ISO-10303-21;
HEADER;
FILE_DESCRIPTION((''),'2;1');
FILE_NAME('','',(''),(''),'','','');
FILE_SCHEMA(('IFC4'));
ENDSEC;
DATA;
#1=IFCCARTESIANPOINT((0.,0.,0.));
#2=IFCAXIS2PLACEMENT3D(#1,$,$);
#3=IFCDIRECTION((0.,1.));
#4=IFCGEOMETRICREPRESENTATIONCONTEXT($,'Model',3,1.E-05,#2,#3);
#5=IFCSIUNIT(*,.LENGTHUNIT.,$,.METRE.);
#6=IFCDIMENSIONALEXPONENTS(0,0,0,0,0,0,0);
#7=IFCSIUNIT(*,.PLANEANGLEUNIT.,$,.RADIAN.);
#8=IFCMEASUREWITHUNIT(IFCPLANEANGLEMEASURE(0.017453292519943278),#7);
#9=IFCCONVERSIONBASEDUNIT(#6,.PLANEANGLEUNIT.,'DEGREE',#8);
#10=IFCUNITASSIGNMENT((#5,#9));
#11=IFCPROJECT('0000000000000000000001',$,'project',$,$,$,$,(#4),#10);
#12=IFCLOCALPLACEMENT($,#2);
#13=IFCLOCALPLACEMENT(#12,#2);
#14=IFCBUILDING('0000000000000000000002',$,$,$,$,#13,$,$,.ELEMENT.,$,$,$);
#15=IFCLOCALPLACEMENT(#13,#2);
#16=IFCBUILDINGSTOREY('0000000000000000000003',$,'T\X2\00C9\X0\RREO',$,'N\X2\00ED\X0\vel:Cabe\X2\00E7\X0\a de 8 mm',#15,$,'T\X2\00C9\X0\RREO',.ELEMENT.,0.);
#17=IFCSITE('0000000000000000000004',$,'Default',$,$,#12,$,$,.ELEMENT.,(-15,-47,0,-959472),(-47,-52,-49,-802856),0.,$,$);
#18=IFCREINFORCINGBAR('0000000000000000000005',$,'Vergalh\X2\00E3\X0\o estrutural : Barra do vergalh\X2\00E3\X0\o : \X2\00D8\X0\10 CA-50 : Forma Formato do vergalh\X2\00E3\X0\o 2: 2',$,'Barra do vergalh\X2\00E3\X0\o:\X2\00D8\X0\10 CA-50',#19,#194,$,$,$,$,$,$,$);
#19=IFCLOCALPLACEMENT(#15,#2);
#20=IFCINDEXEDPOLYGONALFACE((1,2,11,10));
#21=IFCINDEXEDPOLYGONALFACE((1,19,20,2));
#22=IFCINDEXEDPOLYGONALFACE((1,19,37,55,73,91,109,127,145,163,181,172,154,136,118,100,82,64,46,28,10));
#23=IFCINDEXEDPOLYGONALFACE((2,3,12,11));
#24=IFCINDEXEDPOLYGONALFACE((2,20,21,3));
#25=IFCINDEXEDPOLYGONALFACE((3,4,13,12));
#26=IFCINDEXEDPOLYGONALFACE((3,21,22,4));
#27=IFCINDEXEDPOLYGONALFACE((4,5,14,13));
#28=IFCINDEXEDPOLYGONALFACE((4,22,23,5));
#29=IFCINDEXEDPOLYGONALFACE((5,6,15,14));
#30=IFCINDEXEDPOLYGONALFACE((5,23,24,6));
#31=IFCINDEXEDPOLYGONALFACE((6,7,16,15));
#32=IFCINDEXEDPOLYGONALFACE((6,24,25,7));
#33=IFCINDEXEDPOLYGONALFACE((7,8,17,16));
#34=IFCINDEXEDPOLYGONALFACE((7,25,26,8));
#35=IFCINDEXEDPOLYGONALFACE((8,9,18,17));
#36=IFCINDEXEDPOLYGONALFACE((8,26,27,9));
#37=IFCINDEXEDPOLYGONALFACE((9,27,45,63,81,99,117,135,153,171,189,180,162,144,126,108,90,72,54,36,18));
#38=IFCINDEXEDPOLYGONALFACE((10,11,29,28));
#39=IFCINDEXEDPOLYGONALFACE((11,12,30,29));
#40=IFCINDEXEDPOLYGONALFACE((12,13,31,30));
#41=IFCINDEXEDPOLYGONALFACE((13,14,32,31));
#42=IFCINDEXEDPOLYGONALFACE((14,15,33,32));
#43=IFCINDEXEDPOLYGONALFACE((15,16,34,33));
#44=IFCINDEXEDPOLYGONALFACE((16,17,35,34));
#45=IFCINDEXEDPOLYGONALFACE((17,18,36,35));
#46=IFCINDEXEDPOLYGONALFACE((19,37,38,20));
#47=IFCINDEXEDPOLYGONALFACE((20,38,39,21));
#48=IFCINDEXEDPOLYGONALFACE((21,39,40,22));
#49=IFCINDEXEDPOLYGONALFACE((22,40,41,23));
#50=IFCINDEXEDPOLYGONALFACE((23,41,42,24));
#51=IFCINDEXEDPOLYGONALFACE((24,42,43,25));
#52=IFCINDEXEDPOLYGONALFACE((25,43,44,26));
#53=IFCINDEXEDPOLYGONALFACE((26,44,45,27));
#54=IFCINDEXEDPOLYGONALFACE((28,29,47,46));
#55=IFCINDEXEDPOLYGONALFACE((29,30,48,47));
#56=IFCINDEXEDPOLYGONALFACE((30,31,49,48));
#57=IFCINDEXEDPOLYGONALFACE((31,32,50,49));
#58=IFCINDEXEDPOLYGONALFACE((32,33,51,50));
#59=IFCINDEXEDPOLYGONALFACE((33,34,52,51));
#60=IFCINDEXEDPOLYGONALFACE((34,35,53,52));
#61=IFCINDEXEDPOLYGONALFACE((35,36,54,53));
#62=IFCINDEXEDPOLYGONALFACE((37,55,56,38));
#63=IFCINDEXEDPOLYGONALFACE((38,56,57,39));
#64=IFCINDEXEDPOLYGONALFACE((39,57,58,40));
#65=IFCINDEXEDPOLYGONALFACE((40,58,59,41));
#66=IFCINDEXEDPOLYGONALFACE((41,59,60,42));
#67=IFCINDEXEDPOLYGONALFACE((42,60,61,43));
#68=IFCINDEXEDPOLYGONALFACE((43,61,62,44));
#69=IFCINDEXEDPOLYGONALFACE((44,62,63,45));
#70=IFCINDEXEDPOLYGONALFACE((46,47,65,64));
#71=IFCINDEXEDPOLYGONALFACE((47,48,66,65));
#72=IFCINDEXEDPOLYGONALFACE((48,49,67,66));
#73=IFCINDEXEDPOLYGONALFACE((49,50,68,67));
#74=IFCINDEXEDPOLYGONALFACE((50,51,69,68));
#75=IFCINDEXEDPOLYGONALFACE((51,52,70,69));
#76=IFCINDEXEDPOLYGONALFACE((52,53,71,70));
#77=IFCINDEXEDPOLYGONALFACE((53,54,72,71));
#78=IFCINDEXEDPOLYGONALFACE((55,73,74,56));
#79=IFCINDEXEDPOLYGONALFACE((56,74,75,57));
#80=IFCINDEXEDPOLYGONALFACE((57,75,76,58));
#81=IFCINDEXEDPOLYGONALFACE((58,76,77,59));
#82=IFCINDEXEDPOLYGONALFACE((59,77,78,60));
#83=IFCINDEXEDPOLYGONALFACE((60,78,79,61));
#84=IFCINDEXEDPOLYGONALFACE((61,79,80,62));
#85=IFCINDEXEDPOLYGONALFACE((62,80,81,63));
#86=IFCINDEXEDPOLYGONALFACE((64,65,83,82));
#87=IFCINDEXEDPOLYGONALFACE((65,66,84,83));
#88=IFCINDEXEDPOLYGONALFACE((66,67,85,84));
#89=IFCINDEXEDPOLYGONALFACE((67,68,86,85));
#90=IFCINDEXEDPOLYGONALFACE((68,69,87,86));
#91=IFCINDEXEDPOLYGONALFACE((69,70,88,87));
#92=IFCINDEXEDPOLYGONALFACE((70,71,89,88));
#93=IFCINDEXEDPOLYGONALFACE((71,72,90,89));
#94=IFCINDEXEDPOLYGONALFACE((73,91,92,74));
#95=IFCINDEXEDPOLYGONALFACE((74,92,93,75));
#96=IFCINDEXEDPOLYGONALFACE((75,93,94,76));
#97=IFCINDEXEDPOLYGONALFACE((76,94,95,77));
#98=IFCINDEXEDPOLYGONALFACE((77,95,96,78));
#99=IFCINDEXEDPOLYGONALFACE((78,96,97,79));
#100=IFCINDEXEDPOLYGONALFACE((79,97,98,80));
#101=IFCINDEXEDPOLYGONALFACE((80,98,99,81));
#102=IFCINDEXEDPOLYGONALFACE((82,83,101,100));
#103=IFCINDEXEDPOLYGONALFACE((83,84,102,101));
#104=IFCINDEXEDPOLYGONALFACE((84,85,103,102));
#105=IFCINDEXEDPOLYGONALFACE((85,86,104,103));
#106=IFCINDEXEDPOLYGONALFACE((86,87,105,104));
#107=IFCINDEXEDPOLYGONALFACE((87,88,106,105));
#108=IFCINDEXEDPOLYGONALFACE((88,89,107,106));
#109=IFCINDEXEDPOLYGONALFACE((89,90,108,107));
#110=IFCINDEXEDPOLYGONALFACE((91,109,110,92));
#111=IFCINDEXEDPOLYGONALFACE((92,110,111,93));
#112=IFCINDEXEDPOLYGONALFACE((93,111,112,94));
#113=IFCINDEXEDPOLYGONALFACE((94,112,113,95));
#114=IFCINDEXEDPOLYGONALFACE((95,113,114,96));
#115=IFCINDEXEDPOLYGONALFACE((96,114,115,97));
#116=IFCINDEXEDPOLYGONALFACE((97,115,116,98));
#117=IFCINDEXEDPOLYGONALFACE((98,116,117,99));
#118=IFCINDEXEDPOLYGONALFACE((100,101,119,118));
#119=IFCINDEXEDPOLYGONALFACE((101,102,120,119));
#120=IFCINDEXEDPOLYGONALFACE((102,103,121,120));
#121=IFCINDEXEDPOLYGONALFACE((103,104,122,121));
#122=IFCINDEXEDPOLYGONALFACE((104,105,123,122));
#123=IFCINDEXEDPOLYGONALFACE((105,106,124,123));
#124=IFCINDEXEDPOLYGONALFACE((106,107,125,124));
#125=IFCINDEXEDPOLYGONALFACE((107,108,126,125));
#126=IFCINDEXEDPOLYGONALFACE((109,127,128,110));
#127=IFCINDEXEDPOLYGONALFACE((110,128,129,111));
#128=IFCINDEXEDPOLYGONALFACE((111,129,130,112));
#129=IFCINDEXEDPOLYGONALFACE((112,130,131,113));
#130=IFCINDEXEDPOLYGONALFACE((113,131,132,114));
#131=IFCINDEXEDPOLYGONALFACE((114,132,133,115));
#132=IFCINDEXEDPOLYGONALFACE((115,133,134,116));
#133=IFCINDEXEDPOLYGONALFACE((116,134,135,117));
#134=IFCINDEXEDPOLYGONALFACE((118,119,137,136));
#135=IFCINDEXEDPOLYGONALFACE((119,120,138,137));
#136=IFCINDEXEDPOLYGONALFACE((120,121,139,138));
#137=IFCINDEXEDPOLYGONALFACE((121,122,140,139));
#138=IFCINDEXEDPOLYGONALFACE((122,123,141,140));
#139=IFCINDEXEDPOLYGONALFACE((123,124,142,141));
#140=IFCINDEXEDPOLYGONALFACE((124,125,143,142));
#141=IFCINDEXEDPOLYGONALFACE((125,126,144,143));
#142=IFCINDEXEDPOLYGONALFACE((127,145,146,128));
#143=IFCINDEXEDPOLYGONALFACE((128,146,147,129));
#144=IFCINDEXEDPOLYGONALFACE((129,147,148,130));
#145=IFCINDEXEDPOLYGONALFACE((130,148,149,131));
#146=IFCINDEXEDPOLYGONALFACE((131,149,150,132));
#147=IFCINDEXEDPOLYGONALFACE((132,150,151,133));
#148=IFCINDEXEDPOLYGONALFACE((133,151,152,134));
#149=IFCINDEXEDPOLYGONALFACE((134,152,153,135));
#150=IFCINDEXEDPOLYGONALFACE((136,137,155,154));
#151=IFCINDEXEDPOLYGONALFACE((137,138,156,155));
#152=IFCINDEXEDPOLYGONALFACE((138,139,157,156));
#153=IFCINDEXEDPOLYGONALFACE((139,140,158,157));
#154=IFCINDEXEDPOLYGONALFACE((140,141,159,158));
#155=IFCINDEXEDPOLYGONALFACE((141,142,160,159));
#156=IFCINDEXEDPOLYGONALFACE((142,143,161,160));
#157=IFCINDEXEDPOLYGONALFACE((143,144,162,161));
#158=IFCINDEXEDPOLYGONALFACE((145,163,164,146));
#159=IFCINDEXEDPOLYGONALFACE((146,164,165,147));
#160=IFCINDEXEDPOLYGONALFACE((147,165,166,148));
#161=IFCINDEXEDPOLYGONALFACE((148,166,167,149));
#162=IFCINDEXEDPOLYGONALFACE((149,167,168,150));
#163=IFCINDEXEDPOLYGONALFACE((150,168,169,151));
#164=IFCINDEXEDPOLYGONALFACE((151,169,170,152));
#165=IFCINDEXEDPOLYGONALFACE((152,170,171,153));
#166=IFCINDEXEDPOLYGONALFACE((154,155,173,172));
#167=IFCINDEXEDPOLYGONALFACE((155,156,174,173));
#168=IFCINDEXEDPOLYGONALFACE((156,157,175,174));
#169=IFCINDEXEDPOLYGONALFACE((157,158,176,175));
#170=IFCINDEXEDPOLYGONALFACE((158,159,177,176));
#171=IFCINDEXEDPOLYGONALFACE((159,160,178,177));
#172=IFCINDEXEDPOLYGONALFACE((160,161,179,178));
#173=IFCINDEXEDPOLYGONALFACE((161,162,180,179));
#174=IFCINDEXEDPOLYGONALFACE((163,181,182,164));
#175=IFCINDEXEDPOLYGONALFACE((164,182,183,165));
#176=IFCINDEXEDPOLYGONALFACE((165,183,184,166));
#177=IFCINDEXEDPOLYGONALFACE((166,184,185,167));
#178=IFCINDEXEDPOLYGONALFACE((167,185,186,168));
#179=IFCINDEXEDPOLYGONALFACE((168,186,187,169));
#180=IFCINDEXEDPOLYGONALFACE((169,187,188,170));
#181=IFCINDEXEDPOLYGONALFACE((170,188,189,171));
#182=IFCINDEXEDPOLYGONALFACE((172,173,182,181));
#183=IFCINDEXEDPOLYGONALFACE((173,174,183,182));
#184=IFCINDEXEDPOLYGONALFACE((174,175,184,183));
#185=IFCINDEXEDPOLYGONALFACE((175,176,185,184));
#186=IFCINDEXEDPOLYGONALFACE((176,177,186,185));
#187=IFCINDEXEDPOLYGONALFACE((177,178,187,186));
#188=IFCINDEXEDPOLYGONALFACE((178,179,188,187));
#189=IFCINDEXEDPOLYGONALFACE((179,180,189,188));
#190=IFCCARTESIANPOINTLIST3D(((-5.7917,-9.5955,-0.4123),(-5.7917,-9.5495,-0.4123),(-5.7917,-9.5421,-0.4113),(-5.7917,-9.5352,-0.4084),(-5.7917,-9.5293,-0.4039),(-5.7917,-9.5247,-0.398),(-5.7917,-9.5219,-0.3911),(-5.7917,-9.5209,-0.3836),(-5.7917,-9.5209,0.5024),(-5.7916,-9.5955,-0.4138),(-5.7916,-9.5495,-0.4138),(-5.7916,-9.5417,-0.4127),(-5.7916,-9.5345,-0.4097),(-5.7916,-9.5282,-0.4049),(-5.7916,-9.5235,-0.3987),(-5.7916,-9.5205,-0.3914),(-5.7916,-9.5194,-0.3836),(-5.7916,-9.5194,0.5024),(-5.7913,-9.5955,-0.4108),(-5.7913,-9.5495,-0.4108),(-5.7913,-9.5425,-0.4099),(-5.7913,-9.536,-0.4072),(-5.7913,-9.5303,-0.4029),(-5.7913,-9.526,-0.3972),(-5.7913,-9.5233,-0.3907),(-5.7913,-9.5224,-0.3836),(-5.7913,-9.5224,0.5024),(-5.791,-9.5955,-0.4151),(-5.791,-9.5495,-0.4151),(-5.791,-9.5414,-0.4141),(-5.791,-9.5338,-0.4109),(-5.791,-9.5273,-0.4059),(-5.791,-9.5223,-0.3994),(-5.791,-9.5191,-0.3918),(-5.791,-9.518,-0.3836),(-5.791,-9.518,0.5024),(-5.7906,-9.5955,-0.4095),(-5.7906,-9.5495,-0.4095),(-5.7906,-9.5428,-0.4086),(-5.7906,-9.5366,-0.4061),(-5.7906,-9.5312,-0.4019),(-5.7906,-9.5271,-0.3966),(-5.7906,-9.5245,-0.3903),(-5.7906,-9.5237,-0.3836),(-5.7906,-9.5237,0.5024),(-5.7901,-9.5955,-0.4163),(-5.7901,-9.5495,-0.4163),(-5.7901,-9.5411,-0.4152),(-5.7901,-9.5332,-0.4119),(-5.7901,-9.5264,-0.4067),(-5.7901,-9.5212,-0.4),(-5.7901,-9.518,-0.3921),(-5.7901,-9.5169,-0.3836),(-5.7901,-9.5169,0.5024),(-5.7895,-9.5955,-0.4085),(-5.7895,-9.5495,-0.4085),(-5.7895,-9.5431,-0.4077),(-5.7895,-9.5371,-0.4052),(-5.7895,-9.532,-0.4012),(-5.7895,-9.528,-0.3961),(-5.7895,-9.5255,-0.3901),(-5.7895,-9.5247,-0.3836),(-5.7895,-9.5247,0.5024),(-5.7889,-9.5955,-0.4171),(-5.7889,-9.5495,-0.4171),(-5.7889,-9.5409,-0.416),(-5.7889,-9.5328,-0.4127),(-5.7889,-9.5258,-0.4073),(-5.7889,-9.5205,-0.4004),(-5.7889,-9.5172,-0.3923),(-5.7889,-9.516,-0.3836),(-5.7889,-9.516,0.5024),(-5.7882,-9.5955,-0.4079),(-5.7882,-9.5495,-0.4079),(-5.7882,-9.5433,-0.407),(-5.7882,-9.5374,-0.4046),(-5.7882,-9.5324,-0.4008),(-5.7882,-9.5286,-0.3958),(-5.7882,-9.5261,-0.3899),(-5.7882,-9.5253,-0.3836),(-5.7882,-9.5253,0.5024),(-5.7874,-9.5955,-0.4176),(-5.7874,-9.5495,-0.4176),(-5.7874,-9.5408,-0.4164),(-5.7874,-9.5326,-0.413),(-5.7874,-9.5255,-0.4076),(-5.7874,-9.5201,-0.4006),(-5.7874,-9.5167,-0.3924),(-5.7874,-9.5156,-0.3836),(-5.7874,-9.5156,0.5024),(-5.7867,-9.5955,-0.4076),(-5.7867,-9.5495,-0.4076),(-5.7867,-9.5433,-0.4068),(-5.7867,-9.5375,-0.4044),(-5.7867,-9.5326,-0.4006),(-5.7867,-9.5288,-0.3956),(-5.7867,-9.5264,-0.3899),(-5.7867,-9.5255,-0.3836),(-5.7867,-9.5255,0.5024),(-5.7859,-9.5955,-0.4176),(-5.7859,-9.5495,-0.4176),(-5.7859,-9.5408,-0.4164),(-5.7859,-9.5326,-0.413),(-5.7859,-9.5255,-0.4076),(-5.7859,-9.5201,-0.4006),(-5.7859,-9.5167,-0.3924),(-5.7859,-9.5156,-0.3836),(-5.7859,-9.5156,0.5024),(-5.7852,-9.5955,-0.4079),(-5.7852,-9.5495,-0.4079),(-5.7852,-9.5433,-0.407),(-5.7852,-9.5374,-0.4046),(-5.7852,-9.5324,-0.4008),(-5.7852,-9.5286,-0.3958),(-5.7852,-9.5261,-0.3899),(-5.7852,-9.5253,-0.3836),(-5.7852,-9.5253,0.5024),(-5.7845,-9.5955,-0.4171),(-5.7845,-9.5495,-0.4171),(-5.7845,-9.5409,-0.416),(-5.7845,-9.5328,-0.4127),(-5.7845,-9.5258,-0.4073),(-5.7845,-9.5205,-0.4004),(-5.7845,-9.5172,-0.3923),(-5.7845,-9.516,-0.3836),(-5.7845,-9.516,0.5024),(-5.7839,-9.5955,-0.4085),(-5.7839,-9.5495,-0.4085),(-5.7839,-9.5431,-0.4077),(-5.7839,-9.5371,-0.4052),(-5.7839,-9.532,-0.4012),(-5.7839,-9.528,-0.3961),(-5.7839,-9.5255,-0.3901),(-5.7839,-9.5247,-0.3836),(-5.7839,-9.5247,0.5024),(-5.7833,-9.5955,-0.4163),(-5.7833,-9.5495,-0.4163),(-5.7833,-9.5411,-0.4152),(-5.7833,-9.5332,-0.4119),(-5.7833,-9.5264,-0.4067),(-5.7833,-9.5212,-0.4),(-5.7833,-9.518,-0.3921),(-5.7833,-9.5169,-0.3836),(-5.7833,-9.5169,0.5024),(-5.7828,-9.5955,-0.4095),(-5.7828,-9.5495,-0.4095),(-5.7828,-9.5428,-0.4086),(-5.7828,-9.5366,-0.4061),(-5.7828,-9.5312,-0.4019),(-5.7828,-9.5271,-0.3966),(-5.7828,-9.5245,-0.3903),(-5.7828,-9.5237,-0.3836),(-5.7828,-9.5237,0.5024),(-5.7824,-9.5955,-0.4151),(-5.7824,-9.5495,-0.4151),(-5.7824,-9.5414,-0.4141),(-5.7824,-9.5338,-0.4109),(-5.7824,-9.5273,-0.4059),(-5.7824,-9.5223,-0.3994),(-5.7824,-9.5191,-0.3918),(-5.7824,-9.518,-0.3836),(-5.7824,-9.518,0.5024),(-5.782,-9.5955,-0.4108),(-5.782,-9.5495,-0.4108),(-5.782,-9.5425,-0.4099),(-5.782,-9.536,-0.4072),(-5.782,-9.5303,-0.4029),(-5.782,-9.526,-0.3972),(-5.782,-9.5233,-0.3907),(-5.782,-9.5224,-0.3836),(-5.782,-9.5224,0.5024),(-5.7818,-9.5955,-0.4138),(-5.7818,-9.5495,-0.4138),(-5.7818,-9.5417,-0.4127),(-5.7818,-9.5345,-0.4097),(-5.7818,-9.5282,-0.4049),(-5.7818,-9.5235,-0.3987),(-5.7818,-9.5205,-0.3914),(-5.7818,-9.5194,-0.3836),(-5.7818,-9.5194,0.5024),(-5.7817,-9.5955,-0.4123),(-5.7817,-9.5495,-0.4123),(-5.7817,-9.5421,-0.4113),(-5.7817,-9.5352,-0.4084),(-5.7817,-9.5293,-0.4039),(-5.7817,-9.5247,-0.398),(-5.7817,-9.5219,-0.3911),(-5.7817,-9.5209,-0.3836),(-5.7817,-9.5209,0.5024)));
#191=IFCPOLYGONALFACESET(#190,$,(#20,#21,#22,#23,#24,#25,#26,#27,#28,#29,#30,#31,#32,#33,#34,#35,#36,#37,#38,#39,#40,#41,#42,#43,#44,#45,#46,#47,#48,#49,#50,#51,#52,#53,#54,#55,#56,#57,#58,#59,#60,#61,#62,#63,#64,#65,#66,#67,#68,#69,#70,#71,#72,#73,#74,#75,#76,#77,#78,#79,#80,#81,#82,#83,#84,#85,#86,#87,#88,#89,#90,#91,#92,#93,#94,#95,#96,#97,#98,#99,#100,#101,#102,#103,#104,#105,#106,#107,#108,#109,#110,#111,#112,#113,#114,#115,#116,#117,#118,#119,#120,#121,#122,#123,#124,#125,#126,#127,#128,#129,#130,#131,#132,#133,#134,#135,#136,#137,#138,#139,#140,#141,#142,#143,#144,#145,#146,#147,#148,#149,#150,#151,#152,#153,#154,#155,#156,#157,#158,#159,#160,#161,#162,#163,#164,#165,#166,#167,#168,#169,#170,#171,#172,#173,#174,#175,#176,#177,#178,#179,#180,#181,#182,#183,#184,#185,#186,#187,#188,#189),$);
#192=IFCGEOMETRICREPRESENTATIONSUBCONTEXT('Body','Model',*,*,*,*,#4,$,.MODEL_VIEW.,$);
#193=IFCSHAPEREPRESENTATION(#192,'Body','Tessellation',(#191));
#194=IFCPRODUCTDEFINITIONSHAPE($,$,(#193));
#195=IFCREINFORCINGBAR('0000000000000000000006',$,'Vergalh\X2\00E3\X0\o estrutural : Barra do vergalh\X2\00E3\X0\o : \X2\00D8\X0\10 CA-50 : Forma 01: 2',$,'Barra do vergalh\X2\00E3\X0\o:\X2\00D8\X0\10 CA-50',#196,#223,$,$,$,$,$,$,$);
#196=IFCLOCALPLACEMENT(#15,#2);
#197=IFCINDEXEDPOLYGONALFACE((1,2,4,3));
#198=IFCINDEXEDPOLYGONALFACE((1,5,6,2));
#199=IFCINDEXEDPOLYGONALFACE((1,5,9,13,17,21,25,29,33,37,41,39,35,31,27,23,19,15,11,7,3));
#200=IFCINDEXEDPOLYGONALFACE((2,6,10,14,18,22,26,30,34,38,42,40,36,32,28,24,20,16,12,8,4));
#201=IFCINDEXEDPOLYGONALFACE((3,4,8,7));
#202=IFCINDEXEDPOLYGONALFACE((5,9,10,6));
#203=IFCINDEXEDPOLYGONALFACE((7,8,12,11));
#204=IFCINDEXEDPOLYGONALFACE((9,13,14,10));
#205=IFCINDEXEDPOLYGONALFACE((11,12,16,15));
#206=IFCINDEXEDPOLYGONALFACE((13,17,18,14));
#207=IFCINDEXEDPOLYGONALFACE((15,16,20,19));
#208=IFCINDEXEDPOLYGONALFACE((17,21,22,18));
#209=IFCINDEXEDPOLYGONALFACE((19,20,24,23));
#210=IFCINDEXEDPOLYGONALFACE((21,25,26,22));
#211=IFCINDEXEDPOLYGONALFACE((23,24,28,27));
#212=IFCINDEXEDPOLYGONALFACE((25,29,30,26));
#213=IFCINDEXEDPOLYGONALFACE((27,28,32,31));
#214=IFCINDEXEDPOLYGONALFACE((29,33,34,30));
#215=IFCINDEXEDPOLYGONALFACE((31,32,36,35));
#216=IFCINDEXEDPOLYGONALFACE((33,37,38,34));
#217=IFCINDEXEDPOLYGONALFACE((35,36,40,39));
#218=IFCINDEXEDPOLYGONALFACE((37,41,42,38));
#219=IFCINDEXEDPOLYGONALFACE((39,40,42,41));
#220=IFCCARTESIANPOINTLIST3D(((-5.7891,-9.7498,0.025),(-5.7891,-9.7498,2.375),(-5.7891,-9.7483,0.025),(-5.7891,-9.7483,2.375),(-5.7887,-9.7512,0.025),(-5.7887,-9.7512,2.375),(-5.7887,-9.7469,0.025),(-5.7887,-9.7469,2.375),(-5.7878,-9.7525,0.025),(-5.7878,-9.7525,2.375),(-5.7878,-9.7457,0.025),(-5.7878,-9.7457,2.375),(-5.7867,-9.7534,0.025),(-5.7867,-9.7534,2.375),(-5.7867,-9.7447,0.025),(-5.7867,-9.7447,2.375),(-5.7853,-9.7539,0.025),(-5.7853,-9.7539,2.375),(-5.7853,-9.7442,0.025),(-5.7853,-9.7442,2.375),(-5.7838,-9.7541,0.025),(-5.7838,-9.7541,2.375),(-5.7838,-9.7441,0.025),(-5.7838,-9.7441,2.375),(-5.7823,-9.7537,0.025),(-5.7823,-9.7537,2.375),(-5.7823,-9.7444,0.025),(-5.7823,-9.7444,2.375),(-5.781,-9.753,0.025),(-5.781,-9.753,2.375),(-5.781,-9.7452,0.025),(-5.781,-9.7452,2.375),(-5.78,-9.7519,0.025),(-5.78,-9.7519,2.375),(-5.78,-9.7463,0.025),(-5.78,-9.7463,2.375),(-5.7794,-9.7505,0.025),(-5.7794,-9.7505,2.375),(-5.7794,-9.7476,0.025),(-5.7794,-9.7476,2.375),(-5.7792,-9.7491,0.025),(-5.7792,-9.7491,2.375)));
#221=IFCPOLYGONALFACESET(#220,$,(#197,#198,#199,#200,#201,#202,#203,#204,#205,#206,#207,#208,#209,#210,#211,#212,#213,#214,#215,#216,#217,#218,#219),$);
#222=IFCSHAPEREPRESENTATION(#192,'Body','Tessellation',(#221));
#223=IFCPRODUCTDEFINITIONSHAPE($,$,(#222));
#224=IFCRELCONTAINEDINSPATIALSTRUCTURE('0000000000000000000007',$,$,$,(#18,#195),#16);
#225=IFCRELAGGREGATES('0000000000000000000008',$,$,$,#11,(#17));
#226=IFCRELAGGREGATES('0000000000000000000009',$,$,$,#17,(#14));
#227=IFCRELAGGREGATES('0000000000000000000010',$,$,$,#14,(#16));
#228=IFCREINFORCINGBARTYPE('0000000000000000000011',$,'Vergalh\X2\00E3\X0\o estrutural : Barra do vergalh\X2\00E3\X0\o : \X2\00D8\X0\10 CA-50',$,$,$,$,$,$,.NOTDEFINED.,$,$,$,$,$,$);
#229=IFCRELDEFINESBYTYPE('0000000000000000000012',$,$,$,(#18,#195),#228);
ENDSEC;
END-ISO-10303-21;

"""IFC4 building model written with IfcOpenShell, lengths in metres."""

from ifc_helpers import new_model, entity, si_unit, converted_unit, direction, origin, place, context, subcontext, project, spatial, type_object, element, save


model = new_model("IFC4")

# Units and contexts
model_context = context("Model", 3, precision=1e-05, world=origin(), true_north=direction((0.0, 1.0)))
body_context = subcontext(model_context, "Body", "Model", "MODEL_VIEW")
ifc_project = project(units=[si_unit("LENGTHUNIT", "METRE"), converted_unit("PLANEANGLEUNIT", "DEGREE", entity("IfcPlaneAngleMeasure", 0.017453292519943278), si_unit("PLANEANGLEUNIT", "RADIAN"), dimensions=[0, 0, 0, 0, 0, 0, 0])], contexts=[model_context])

# Site, building, storey
site_placement = place(None, origin())
site = spatial("IfcSite", under=ifc_project, at=site_placement, Name="Default", CompositionType="ELEMENT", RefLatitude=(-15, -47, 0, -959472), RefLongitude=(-47, -52, -49, -802856), RefElevation=0.0)
building_placement = place(site_placement, origin())
building = spatial("IfcBuilding", under=site, at=building_placement, CompositionType="ELEMENT")
storey_placement = place(building_placement, origin())
storey = spatial("IfcBuildingStorey", under=building, at=storey_placement, Name="TÉRREO", ObjectType="Nível:Cabeça de 8 mm", LongName="TÉRREO", CompositionType="ELEMENT", Elevation=0.0)

# Reinforcing bars
reinforcing_bar_type_1 = type_object("IfcReinforcingBarType", Name="Vergalhão estrutural : Barra do vergalhão : Ø10 CA-50", PredefinedType="NOTDEFINED")
reinforcing_bar_1_placement = place(storey_placement, origin())
element("IfcReinforcingBar", 1, at=reinforcing_bar_1_placement, inside=storey, type_object=reinforcing_bar_type_1, Name="Vergalhão estrutural : Barra do vergalhão : Ø10 CA-50 : Forma Formato do vergalhão 2: 2", ObjectType="Barra do vergalhão:Ø10 CA-50", context=body_context, shape_type="AdvancedSweptSolid", body=[
    entity("IfcSweptDiskSolid", entity("IfcIndexedPolyCurve", entity("IfcCartesianPointList3D", [[-5.7867, -9.5955, -0.4126], [-5.7867, -9.5495, -0.4126], [-5.7867, -9.529, -0.4042], [-5.7867, -9.5205, -0.3836], [-5.7867, -9.5205, 0.5024]]), [entity("IfcLineIndex", [1, 2]), entity("IfcArcIndex", [2, 3, 4]), entity("IfcLineIndex", [4, 5])], False), 0.005, None, 0.0, 92.0),
])
reinforcing_bar_2_placement = place(storey_placement, origin())
element("IfcReinforcingBar", 2, at=reinforcing_bar_2_placement, inside=storey, type_object=reinforcing_bar_type_1, Name="Vergalhão estrutural : Barra do vergalhão : Ø10 CA-50 : Forma 01: 2", ObjectType="Barra do vergalhão:Ø10 CA-50", context=body_context, shape_type="AdvancedSweptSolid", body=[
    entity("IfcSweptDiskSolid", entity("IfcIndexedPolyCurve", entity("IfcCartesianPointList3D", [[-5.7842, -9.7491, 0.025], [-5.7842, -9.7491, 2.375]]), None, False), 0.005, None, 0.0, 1.0),
])

save(model, "model.ifc")
